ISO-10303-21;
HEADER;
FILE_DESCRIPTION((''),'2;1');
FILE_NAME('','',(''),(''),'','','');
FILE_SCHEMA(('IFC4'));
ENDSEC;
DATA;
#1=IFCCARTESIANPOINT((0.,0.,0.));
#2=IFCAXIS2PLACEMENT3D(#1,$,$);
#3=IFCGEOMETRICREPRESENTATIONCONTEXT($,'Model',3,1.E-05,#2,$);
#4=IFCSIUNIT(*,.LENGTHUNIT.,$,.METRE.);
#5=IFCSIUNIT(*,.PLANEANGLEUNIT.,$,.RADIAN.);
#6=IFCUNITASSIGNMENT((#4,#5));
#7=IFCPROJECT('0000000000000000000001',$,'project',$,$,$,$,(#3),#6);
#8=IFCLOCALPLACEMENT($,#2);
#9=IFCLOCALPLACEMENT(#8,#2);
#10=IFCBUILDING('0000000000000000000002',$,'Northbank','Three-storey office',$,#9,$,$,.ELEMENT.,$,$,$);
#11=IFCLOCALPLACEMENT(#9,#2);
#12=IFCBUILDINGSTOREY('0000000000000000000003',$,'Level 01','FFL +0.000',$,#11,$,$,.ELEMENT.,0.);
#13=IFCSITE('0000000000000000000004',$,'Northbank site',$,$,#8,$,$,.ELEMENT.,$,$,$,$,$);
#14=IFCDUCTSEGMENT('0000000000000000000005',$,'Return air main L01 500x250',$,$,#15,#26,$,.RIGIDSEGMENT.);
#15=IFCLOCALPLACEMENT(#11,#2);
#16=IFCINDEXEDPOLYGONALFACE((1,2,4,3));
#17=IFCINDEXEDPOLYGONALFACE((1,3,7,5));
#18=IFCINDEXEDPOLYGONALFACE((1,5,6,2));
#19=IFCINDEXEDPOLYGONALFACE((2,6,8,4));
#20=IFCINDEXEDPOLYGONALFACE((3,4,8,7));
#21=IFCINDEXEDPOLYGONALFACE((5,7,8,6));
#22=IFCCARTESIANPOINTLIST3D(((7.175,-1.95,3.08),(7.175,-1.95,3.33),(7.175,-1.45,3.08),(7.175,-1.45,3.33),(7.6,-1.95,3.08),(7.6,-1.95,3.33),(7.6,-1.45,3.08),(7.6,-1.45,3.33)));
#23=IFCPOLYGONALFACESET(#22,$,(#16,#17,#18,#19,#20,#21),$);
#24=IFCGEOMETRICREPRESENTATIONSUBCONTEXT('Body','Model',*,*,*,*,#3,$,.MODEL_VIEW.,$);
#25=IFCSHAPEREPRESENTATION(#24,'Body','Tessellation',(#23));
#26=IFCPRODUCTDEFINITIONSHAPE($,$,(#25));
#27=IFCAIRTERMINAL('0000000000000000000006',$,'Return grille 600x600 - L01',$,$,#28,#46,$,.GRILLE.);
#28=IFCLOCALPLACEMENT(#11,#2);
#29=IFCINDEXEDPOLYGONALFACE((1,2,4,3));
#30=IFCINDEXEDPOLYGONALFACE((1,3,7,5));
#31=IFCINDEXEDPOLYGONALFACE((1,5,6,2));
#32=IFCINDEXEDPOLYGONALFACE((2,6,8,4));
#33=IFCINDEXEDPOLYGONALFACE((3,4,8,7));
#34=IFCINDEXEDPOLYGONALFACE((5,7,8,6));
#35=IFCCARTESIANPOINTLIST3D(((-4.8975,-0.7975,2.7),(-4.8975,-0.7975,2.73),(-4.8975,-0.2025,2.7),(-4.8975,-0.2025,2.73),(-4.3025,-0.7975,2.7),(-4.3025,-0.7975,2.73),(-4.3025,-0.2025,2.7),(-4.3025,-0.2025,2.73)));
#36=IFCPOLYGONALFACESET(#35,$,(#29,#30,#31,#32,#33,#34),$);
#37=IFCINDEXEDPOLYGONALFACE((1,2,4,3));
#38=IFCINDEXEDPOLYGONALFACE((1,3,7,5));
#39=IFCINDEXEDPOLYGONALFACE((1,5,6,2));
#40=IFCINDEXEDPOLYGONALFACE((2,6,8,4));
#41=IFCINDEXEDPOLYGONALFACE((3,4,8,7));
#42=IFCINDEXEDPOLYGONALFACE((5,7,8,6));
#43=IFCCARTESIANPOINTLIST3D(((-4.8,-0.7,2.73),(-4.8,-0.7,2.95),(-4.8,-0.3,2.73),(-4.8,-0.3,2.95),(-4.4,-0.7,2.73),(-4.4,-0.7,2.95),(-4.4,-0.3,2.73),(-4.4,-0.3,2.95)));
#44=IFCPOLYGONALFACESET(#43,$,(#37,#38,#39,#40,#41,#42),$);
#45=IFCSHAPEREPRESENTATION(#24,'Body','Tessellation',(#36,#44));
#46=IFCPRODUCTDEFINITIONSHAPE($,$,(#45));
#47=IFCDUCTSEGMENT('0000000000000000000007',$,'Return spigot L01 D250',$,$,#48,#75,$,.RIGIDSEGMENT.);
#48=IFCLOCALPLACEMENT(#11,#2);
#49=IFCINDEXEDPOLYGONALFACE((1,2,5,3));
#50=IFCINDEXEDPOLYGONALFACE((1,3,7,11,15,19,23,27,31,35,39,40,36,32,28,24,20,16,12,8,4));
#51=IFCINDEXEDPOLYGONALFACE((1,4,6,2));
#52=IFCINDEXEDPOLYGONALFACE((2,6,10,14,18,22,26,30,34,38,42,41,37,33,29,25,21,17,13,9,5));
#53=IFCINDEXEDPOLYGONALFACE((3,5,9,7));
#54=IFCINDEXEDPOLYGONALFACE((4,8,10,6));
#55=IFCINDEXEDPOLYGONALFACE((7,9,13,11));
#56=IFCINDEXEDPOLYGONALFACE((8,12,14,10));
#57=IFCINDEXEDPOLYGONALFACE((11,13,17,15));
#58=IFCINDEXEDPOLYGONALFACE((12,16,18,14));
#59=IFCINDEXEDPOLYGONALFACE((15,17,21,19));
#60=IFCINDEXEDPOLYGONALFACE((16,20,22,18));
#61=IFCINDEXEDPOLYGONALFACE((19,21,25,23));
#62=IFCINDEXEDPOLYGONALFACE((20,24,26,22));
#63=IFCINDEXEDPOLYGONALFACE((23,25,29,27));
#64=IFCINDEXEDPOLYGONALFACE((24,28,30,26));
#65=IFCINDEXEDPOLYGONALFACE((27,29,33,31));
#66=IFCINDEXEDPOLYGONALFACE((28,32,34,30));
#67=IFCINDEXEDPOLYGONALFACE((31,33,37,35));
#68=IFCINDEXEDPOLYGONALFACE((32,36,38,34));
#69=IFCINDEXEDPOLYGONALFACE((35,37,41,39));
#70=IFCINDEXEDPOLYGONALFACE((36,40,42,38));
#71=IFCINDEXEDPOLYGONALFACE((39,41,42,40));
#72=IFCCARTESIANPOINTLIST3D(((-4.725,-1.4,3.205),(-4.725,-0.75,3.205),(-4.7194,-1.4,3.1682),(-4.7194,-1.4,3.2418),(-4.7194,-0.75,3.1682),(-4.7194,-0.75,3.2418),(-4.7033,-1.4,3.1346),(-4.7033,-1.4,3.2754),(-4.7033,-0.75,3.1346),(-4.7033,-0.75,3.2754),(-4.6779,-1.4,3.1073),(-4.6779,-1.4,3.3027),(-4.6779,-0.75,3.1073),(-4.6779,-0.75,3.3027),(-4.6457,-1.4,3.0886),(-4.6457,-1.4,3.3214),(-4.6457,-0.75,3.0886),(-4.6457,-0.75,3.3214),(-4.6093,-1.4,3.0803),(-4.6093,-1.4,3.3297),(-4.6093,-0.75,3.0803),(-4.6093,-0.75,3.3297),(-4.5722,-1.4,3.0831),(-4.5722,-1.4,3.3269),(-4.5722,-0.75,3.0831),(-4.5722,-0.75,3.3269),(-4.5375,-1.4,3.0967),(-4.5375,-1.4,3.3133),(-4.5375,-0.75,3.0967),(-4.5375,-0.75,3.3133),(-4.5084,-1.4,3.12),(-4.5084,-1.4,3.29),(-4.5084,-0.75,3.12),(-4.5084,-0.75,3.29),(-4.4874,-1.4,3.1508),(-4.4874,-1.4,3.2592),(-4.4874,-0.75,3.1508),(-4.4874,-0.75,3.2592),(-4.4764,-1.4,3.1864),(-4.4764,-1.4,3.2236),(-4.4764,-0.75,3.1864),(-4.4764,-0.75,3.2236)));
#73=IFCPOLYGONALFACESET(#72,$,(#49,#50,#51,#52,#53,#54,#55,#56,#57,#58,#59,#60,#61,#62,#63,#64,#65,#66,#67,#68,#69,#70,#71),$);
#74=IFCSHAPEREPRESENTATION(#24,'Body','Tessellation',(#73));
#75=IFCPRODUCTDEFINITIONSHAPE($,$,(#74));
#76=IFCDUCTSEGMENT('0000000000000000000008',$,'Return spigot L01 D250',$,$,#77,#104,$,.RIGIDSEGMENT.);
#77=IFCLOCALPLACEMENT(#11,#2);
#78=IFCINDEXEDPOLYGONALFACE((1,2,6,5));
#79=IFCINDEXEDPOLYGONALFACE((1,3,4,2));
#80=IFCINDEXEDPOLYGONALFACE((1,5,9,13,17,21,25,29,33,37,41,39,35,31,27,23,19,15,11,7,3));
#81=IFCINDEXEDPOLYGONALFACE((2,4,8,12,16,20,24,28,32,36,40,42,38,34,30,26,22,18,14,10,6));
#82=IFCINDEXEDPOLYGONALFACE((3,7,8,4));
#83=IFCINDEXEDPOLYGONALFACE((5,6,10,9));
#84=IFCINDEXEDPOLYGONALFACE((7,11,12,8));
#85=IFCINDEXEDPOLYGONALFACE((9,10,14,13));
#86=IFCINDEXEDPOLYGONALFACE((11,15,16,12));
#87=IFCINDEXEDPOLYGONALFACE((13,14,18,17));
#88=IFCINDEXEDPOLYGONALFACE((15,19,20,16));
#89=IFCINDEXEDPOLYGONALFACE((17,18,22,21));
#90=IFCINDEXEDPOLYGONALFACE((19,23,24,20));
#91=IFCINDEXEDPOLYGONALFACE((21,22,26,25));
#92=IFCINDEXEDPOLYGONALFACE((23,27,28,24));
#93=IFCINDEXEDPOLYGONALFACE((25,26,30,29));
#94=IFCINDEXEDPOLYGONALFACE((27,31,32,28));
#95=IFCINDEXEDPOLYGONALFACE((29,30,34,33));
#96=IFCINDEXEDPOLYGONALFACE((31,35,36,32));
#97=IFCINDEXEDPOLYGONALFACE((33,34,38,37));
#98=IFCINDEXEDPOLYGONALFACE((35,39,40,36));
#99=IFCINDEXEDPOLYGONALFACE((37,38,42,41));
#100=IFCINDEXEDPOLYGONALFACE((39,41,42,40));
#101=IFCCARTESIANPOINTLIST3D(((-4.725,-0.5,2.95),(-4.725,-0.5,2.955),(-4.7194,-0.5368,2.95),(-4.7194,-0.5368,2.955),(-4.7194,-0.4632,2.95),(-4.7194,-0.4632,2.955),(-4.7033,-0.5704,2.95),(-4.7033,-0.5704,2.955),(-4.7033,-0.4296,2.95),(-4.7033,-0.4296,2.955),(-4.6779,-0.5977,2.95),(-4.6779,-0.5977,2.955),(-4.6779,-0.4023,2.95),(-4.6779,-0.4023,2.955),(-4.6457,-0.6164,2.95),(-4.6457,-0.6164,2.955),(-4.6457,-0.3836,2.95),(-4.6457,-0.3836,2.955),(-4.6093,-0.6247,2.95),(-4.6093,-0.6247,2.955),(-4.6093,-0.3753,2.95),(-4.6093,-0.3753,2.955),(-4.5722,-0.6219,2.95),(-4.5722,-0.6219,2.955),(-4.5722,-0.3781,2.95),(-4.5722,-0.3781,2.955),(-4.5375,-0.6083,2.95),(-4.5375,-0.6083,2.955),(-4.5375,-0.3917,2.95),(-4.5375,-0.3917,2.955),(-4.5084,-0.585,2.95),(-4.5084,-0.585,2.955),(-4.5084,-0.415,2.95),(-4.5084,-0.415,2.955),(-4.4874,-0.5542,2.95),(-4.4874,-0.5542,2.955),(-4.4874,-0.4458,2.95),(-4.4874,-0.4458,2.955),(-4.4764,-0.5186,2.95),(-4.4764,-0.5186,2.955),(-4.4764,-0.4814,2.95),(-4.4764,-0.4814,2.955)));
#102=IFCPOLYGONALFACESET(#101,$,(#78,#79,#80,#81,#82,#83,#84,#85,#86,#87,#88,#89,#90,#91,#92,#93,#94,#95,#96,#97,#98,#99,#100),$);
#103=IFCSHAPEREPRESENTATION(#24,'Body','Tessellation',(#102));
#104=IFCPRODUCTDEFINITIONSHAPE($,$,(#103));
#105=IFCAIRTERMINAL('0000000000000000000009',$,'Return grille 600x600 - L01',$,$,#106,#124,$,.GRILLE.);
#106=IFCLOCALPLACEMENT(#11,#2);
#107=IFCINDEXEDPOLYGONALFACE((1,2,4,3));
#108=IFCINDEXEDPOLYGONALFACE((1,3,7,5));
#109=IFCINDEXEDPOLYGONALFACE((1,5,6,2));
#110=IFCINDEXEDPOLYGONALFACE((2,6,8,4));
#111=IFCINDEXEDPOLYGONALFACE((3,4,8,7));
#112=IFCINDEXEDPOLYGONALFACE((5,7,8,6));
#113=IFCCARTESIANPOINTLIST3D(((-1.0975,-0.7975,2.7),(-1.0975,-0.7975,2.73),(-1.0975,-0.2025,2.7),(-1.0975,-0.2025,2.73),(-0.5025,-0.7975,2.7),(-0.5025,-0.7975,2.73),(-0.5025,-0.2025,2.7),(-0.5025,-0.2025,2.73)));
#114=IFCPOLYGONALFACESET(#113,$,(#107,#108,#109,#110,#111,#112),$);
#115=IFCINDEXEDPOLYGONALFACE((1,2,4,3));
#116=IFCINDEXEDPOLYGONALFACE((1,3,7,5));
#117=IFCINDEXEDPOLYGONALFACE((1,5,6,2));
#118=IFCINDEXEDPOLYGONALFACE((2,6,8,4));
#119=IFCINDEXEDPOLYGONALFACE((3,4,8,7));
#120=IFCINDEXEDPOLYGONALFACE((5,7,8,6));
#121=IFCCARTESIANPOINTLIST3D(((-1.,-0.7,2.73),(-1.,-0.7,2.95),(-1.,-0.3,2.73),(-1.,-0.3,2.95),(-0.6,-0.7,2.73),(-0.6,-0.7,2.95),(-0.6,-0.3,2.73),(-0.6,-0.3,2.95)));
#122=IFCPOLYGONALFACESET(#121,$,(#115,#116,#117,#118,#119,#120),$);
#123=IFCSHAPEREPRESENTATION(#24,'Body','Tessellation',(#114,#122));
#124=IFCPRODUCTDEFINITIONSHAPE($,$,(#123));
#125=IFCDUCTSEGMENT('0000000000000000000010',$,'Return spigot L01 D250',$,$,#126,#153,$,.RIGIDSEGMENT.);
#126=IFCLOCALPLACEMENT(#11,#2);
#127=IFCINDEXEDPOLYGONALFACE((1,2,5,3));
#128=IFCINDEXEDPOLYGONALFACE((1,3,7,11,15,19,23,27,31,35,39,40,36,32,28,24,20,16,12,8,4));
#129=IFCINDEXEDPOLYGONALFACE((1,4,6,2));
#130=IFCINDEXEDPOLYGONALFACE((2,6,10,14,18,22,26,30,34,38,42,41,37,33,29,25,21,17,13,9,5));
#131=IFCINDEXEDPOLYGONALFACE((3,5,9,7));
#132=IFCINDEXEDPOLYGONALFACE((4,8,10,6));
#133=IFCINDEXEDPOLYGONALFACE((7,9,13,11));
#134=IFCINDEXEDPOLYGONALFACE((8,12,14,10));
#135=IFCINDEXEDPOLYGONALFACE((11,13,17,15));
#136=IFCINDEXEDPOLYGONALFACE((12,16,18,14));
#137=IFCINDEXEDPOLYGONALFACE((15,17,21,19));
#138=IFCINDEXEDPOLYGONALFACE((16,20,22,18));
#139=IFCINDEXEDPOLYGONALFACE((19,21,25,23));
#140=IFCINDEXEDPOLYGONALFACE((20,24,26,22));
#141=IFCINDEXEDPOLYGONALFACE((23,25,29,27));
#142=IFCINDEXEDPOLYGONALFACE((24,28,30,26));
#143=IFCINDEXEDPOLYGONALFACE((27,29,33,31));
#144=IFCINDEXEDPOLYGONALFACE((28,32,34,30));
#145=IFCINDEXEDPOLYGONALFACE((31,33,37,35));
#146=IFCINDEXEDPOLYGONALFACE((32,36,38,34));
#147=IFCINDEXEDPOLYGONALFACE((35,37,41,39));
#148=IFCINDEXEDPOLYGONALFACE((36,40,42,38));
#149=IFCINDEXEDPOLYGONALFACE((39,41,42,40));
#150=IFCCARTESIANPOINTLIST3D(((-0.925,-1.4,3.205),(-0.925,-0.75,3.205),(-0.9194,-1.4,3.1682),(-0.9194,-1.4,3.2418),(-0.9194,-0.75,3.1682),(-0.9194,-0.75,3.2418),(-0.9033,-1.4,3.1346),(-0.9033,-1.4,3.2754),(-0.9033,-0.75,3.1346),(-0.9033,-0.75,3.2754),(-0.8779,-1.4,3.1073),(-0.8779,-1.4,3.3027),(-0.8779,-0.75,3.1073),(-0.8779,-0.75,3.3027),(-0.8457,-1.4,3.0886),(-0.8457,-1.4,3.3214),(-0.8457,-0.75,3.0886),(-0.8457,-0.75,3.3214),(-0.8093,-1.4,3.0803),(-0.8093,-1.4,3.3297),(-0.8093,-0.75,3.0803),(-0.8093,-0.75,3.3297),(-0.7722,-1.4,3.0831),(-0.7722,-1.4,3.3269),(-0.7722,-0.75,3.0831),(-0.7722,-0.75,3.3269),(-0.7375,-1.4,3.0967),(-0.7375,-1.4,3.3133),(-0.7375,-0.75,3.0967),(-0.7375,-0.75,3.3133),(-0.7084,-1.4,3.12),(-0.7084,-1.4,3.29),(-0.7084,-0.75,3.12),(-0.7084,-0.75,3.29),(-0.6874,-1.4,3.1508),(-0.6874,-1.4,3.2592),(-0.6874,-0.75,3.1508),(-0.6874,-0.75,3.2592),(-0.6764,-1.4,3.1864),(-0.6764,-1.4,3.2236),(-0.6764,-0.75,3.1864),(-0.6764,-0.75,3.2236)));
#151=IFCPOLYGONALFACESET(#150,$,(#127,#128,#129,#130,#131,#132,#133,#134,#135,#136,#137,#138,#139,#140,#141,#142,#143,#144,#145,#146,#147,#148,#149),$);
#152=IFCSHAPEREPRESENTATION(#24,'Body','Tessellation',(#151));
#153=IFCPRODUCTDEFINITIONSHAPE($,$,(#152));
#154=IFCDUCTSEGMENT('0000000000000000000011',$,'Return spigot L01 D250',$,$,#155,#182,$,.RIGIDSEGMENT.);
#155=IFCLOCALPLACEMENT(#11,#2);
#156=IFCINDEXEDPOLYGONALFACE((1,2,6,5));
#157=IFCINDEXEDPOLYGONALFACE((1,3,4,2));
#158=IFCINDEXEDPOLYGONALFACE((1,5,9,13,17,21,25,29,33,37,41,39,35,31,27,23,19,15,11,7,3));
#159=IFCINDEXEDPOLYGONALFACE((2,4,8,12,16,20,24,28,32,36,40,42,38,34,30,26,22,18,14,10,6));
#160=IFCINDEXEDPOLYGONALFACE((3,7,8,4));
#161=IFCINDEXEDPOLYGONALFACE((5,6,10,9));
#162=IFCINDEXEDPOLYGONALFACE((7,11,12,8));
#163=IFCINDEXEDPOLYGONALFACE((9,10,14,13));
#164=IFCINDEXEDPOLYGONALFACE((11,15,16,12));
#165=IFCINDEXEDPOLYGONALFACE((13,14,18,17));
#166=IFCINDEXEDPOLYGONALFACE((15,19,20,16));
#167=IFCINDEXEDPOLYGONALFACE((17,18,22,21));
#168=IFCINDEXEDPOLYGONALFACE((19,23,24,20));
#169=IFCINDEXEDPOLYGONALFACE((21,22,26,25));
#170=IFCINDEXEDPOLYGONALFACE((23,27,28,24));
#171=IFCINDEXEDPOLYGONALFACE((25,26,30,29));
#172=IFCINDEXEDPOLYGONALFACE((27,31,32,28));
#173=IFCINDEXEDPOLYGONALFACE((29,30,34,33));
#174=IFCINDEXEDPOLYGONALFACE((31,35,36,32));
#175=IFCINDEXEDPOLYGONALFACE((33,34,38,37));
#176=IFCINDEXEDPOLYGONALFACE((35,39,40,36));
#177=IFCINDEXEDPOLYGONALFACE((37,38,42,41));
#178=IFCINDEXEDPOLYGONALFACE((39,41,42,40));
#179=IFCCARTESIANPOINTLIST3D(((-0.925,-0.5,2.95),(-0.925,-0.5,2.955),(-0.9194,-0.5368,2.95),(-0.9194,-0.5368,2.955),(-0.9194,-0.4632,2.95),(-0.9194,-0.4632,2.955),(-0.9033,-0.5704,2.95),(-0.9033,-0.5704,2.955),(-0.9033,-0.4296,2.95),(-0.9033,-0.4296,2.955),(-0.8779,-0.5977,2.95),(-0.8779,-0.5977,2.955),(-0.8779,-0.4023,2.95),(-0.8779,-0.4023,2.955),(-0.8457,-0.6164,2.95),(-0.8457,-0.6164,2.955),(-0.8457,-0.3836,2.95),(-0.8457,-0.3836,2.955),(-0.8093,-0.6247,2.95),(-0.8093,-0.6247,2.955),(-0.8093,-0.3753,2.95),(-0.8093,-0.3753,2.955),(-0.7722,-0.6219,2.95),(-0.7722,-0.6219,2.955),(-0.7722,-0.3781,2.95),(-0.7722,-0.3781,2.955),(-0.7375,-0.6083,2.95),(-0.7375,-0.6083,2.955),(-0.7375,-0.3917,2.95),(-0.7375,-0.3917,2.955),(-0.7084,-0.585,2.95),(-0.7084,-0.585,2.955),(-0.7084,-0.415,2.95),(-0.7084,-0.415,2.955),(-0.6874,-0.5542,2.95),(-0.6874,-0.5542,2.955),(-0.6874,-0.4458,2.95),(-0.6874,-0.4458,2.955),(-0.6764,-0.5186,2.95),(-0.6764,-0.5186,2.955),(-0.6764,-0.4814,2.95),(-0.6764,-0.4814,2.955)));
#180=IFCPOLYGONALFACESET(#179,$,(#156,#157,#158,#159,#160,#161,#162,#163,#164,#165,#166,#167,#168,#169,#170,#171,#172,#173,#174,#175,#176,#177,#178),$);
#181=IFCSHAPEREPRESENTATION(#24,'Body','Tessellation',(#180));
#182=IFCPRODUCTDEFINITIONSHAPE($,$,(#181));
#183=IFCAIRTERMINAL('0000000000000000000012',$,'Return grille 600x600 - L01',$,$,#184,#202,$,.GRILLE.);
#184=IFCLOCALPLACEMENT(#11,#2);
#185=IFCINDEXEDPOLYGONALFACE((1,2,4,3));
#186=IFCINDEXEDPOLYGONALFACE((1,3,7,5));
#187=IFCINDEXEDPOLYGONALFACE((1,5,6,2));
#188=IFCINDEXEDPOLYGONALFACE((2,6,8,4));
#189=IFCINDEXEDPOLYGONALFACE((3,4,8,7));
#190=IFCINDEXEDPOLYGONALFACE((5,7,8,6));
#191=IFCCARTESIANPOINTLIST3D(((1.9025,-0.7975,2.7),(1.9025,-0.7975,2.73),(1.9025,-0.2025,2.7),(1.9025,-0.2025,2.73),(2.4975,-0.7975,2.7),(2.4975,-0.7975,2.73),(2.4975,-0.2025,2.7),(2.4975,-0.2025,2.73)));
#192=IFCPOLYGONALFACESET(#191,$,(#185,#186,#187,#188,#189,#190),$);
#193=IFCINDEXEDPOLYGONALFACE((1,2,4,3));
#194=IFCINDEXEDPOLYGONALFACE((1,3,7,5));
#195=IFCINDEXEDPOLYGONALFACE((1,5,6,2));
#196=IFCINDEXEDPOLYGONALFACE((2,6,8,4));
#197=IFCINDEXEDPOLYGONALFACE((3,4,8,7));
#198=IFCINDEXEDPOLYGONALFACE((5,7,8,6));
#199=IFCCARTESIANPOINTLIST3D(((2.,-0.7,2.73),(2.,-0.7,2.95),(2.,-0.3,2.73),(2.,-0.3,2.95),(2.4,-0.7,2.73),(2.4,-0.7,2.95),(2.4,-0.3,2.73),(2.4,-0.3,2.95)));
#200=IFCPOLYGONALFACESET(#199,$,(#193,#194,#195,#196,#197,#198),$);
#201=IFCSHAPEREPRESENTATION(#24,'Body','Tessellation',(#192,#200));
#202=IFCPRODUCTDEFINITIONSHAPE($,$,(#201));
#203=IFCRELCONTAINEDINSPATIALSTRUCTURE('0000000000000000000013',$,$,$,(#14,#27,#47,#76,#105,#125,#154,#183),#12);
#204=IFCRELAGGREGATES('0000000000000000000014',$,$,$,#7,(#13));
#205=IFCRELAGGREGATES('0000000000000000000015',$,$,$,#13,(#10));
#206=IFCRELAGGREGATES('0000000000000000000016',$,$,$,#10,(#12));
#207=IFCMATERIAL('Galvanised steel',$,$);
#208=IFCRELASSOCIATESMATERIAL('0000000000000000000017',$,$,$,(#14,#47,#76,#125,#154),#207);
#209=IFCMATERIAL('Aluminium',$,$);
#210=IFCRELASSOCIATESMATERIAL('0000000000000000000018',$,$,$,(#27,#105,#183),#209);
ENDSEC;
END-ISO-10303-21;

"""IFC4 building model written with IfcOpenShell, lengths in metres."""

from ifc_helpers import new_model, si_unit, frame, origin, place, context, subcontext, project, spatial, rectangle, circle, extrude, material, element, save


model = new_model("IFC4")

# Units and contexts
model_context = context("Model", 3, precision=1e-05, world=origin())
body_context = subcontext(model_context, "Body", "Model", "MODEL_VIEW")
ifc_project = project(units=[si_unit("LENGTHUNIT", "METRE"), si_unit("PLANEANGLEUNIT", "RADIAN")], contexts=[model_context])

# Site, building, storey
site_placement = place(None, origin())
site = spatial("IfcSite", under=ifc_project, at=site_placement, Name="Northbank site", CompositionType="ELEMENT")
building_placement = place(site_placement, origin())
building = spatial("IfcBuilding", under=site, at=building_placement, Name="Northbank", Description="Three-storey office", CompositionType="ELEMENT")
storey_placement = place(building_placement, origin())
storey = spatial("IfcBuildingStorey", under=building, at=storey_placement, Name="Level 01", Description="FFL +0.000", CompositionType="ELEMENT", Elevation=0.0)

# Duct segment
ifc_material_1 = material(Name="Galvanised steel")
duct_segment_1_placement = place(storey_placement, origin())
element("IfcDuctSegment", 1, at=duct_segment_1_placement, inside=storey, material=ifc_material_1, Name="Return air main L01 500x250", PredefinedType="RIGIDSEGMENT", context=body_context, shape_type="SweptSolid", body=[
    extrude(rectangle(XDim=0.5, YDim=0.25), frame((7.175, -1.7, 3.205), z_axis=(1.0, 0.0, 0.0), x_axis=(0.0, 1.0, 0.0)), (0.0, 0.0, 1.0), 0.425),
])

# Air terminal
ifc_material_2 = material(Name="Aluminium")
air_terminal_1_placement = place(storey_placement, origin())
element("IfcAirTerminal", 2, at=air_terminal_1_placement, inside=storey, material=ifc_material_2, Name="Return grille 600x600 - L01", PredefinedType="GRILLE", context=body_context, shape_type="SweptSolid", body=[
    extrude(rectangle(XDim=0.595, YDim=0.595), frame((-4.6, -0.5, 2.7)), (0.0, 0.0, 1.0), 0.03),
    extrude(rectangle(XDim=0.4, YDim=0.4), frame((-4.6, -0.5, 2.73)), (0.0, 0.0, 1.0), 0.22),
])

# Duct segments
duct_segment_2_placement = place(storey_placement, origin())
element("IfcDuctSegment", 3, at=duct_segment_2_placement, inside=storey, material=ifc_material_1, Name="Return spigot L01 D250", PredefinedType="RIGIDSEGMENT", context=body_context, shape_type="SweptSolid", body=[
    extrude(circle(Radius=0.125), frame((-4.6, -1.4, 3.205), z_axis=(0.0, 1.0, 0.0), x_axis=(-1.0, 0.0, 0.0)), (0.0, 0.0, 1.0), 0.65),
])
duct_segment_3_placement = place(storey_placement, origin())
element("IfcDuctSegment", 4, at=duct_segment_3_placement, inside=storey, material=ifc_material_1, Name="Return spigot L01 D250", PredefinedType="RIGIDSEGMENT", context=body_context, shape_type="SweptSolid", body=[
    extrude(circle(Radius=0.125), frame((-4.6, -0.5, 2.955), z_axis=(0.0, 0.0, -1.0), x_axis=(-1.0, 0.0, 0.0)), (0.0, 0.0, 1.0), 0.005),
])

# Air terminal
air_terminal_2_placement = place(storey_placement, origin())
element("IfcAirTerminal", 5, at=air_terminal_2_placement, inside=storey, material=ifc_material_2, Name="Return grille 600x600 - L01", PredefinedType="GRILLE", context=body_context, shape_type="SweptSolid", body=[
    extrude(rectangle(XDim=0.595, YDim=0.595), frame((-0.8, -0.5, 2.7)), (0.0, 0.0, 1.0), 0.03),
    extrude(rectangle(XDim=0.4, YDim=0.4), frame((-0.8, -0.5, 2.73)), (0.0, 0.0, 1.0), 0.22),
])

# Duct segments
duct_segment_4_placement = place(storey_placement, origin())
element("IfcDuctSegment", 6, at=duct_segment_4_placement, inside=storey, material=ifc_material_1, Name="Return spigot L01 D250", PredefinedType="RIGIDSEGMENT", context=body_context, shape_type="SweptSolid", body=[
    extrude(circle(Radius=0.125), frame((-0.8, -1.4, 3.205), z_axis=(0.0, 1.0, 0.0), x_axis=(-1.0, 0.0, 0.0)), (0.0, 0.0, 1.0), 0.65),
])
duct_segment_5_placement = place(storey_placement, origin())
element("IfcDuctSegment", 7, at=duct_segment_5_placement, inside=storey, material=ifc_material_1, Name="Return spigot L01 D250", PredefinedType="RIGIDSEGMENT", context=body_context, shape_type="SweptSolid", body=[
    extrude(circle(Radius=0.125), frame((-0.8, -0.5, 2.955), z_axis=(0.0, 0.0, -1.0), x_axis=(-1.0, 0.0, 0.0)), (0.0, 0.0, 1.0), 0.005),
])

# Air terminal
air_terminal_3_placement = place(storey_placement, origin())
element("IfcAirTerminal", 8, at=air_terminal_3_placement, inside=storey, material=ifc_material_2, Name="Return grille 600x600 - L01", PredefinedType="GRILLE", context=body_context, shape_type="SweptSolid", body=[
    extrude(rectangle(XDim=0.595, YDim=0.595), frame((2.2, -0.5, 2.7)), (0.0, 0.0, 1.0), 0.03),
    extrude(rectangle(XDim=0.4, YDim=0.4), frame((2.2, -0.5, 2.73)), (0.0, 0.0, 1.0), 0.22),
])

save(model, "model.ifc")
